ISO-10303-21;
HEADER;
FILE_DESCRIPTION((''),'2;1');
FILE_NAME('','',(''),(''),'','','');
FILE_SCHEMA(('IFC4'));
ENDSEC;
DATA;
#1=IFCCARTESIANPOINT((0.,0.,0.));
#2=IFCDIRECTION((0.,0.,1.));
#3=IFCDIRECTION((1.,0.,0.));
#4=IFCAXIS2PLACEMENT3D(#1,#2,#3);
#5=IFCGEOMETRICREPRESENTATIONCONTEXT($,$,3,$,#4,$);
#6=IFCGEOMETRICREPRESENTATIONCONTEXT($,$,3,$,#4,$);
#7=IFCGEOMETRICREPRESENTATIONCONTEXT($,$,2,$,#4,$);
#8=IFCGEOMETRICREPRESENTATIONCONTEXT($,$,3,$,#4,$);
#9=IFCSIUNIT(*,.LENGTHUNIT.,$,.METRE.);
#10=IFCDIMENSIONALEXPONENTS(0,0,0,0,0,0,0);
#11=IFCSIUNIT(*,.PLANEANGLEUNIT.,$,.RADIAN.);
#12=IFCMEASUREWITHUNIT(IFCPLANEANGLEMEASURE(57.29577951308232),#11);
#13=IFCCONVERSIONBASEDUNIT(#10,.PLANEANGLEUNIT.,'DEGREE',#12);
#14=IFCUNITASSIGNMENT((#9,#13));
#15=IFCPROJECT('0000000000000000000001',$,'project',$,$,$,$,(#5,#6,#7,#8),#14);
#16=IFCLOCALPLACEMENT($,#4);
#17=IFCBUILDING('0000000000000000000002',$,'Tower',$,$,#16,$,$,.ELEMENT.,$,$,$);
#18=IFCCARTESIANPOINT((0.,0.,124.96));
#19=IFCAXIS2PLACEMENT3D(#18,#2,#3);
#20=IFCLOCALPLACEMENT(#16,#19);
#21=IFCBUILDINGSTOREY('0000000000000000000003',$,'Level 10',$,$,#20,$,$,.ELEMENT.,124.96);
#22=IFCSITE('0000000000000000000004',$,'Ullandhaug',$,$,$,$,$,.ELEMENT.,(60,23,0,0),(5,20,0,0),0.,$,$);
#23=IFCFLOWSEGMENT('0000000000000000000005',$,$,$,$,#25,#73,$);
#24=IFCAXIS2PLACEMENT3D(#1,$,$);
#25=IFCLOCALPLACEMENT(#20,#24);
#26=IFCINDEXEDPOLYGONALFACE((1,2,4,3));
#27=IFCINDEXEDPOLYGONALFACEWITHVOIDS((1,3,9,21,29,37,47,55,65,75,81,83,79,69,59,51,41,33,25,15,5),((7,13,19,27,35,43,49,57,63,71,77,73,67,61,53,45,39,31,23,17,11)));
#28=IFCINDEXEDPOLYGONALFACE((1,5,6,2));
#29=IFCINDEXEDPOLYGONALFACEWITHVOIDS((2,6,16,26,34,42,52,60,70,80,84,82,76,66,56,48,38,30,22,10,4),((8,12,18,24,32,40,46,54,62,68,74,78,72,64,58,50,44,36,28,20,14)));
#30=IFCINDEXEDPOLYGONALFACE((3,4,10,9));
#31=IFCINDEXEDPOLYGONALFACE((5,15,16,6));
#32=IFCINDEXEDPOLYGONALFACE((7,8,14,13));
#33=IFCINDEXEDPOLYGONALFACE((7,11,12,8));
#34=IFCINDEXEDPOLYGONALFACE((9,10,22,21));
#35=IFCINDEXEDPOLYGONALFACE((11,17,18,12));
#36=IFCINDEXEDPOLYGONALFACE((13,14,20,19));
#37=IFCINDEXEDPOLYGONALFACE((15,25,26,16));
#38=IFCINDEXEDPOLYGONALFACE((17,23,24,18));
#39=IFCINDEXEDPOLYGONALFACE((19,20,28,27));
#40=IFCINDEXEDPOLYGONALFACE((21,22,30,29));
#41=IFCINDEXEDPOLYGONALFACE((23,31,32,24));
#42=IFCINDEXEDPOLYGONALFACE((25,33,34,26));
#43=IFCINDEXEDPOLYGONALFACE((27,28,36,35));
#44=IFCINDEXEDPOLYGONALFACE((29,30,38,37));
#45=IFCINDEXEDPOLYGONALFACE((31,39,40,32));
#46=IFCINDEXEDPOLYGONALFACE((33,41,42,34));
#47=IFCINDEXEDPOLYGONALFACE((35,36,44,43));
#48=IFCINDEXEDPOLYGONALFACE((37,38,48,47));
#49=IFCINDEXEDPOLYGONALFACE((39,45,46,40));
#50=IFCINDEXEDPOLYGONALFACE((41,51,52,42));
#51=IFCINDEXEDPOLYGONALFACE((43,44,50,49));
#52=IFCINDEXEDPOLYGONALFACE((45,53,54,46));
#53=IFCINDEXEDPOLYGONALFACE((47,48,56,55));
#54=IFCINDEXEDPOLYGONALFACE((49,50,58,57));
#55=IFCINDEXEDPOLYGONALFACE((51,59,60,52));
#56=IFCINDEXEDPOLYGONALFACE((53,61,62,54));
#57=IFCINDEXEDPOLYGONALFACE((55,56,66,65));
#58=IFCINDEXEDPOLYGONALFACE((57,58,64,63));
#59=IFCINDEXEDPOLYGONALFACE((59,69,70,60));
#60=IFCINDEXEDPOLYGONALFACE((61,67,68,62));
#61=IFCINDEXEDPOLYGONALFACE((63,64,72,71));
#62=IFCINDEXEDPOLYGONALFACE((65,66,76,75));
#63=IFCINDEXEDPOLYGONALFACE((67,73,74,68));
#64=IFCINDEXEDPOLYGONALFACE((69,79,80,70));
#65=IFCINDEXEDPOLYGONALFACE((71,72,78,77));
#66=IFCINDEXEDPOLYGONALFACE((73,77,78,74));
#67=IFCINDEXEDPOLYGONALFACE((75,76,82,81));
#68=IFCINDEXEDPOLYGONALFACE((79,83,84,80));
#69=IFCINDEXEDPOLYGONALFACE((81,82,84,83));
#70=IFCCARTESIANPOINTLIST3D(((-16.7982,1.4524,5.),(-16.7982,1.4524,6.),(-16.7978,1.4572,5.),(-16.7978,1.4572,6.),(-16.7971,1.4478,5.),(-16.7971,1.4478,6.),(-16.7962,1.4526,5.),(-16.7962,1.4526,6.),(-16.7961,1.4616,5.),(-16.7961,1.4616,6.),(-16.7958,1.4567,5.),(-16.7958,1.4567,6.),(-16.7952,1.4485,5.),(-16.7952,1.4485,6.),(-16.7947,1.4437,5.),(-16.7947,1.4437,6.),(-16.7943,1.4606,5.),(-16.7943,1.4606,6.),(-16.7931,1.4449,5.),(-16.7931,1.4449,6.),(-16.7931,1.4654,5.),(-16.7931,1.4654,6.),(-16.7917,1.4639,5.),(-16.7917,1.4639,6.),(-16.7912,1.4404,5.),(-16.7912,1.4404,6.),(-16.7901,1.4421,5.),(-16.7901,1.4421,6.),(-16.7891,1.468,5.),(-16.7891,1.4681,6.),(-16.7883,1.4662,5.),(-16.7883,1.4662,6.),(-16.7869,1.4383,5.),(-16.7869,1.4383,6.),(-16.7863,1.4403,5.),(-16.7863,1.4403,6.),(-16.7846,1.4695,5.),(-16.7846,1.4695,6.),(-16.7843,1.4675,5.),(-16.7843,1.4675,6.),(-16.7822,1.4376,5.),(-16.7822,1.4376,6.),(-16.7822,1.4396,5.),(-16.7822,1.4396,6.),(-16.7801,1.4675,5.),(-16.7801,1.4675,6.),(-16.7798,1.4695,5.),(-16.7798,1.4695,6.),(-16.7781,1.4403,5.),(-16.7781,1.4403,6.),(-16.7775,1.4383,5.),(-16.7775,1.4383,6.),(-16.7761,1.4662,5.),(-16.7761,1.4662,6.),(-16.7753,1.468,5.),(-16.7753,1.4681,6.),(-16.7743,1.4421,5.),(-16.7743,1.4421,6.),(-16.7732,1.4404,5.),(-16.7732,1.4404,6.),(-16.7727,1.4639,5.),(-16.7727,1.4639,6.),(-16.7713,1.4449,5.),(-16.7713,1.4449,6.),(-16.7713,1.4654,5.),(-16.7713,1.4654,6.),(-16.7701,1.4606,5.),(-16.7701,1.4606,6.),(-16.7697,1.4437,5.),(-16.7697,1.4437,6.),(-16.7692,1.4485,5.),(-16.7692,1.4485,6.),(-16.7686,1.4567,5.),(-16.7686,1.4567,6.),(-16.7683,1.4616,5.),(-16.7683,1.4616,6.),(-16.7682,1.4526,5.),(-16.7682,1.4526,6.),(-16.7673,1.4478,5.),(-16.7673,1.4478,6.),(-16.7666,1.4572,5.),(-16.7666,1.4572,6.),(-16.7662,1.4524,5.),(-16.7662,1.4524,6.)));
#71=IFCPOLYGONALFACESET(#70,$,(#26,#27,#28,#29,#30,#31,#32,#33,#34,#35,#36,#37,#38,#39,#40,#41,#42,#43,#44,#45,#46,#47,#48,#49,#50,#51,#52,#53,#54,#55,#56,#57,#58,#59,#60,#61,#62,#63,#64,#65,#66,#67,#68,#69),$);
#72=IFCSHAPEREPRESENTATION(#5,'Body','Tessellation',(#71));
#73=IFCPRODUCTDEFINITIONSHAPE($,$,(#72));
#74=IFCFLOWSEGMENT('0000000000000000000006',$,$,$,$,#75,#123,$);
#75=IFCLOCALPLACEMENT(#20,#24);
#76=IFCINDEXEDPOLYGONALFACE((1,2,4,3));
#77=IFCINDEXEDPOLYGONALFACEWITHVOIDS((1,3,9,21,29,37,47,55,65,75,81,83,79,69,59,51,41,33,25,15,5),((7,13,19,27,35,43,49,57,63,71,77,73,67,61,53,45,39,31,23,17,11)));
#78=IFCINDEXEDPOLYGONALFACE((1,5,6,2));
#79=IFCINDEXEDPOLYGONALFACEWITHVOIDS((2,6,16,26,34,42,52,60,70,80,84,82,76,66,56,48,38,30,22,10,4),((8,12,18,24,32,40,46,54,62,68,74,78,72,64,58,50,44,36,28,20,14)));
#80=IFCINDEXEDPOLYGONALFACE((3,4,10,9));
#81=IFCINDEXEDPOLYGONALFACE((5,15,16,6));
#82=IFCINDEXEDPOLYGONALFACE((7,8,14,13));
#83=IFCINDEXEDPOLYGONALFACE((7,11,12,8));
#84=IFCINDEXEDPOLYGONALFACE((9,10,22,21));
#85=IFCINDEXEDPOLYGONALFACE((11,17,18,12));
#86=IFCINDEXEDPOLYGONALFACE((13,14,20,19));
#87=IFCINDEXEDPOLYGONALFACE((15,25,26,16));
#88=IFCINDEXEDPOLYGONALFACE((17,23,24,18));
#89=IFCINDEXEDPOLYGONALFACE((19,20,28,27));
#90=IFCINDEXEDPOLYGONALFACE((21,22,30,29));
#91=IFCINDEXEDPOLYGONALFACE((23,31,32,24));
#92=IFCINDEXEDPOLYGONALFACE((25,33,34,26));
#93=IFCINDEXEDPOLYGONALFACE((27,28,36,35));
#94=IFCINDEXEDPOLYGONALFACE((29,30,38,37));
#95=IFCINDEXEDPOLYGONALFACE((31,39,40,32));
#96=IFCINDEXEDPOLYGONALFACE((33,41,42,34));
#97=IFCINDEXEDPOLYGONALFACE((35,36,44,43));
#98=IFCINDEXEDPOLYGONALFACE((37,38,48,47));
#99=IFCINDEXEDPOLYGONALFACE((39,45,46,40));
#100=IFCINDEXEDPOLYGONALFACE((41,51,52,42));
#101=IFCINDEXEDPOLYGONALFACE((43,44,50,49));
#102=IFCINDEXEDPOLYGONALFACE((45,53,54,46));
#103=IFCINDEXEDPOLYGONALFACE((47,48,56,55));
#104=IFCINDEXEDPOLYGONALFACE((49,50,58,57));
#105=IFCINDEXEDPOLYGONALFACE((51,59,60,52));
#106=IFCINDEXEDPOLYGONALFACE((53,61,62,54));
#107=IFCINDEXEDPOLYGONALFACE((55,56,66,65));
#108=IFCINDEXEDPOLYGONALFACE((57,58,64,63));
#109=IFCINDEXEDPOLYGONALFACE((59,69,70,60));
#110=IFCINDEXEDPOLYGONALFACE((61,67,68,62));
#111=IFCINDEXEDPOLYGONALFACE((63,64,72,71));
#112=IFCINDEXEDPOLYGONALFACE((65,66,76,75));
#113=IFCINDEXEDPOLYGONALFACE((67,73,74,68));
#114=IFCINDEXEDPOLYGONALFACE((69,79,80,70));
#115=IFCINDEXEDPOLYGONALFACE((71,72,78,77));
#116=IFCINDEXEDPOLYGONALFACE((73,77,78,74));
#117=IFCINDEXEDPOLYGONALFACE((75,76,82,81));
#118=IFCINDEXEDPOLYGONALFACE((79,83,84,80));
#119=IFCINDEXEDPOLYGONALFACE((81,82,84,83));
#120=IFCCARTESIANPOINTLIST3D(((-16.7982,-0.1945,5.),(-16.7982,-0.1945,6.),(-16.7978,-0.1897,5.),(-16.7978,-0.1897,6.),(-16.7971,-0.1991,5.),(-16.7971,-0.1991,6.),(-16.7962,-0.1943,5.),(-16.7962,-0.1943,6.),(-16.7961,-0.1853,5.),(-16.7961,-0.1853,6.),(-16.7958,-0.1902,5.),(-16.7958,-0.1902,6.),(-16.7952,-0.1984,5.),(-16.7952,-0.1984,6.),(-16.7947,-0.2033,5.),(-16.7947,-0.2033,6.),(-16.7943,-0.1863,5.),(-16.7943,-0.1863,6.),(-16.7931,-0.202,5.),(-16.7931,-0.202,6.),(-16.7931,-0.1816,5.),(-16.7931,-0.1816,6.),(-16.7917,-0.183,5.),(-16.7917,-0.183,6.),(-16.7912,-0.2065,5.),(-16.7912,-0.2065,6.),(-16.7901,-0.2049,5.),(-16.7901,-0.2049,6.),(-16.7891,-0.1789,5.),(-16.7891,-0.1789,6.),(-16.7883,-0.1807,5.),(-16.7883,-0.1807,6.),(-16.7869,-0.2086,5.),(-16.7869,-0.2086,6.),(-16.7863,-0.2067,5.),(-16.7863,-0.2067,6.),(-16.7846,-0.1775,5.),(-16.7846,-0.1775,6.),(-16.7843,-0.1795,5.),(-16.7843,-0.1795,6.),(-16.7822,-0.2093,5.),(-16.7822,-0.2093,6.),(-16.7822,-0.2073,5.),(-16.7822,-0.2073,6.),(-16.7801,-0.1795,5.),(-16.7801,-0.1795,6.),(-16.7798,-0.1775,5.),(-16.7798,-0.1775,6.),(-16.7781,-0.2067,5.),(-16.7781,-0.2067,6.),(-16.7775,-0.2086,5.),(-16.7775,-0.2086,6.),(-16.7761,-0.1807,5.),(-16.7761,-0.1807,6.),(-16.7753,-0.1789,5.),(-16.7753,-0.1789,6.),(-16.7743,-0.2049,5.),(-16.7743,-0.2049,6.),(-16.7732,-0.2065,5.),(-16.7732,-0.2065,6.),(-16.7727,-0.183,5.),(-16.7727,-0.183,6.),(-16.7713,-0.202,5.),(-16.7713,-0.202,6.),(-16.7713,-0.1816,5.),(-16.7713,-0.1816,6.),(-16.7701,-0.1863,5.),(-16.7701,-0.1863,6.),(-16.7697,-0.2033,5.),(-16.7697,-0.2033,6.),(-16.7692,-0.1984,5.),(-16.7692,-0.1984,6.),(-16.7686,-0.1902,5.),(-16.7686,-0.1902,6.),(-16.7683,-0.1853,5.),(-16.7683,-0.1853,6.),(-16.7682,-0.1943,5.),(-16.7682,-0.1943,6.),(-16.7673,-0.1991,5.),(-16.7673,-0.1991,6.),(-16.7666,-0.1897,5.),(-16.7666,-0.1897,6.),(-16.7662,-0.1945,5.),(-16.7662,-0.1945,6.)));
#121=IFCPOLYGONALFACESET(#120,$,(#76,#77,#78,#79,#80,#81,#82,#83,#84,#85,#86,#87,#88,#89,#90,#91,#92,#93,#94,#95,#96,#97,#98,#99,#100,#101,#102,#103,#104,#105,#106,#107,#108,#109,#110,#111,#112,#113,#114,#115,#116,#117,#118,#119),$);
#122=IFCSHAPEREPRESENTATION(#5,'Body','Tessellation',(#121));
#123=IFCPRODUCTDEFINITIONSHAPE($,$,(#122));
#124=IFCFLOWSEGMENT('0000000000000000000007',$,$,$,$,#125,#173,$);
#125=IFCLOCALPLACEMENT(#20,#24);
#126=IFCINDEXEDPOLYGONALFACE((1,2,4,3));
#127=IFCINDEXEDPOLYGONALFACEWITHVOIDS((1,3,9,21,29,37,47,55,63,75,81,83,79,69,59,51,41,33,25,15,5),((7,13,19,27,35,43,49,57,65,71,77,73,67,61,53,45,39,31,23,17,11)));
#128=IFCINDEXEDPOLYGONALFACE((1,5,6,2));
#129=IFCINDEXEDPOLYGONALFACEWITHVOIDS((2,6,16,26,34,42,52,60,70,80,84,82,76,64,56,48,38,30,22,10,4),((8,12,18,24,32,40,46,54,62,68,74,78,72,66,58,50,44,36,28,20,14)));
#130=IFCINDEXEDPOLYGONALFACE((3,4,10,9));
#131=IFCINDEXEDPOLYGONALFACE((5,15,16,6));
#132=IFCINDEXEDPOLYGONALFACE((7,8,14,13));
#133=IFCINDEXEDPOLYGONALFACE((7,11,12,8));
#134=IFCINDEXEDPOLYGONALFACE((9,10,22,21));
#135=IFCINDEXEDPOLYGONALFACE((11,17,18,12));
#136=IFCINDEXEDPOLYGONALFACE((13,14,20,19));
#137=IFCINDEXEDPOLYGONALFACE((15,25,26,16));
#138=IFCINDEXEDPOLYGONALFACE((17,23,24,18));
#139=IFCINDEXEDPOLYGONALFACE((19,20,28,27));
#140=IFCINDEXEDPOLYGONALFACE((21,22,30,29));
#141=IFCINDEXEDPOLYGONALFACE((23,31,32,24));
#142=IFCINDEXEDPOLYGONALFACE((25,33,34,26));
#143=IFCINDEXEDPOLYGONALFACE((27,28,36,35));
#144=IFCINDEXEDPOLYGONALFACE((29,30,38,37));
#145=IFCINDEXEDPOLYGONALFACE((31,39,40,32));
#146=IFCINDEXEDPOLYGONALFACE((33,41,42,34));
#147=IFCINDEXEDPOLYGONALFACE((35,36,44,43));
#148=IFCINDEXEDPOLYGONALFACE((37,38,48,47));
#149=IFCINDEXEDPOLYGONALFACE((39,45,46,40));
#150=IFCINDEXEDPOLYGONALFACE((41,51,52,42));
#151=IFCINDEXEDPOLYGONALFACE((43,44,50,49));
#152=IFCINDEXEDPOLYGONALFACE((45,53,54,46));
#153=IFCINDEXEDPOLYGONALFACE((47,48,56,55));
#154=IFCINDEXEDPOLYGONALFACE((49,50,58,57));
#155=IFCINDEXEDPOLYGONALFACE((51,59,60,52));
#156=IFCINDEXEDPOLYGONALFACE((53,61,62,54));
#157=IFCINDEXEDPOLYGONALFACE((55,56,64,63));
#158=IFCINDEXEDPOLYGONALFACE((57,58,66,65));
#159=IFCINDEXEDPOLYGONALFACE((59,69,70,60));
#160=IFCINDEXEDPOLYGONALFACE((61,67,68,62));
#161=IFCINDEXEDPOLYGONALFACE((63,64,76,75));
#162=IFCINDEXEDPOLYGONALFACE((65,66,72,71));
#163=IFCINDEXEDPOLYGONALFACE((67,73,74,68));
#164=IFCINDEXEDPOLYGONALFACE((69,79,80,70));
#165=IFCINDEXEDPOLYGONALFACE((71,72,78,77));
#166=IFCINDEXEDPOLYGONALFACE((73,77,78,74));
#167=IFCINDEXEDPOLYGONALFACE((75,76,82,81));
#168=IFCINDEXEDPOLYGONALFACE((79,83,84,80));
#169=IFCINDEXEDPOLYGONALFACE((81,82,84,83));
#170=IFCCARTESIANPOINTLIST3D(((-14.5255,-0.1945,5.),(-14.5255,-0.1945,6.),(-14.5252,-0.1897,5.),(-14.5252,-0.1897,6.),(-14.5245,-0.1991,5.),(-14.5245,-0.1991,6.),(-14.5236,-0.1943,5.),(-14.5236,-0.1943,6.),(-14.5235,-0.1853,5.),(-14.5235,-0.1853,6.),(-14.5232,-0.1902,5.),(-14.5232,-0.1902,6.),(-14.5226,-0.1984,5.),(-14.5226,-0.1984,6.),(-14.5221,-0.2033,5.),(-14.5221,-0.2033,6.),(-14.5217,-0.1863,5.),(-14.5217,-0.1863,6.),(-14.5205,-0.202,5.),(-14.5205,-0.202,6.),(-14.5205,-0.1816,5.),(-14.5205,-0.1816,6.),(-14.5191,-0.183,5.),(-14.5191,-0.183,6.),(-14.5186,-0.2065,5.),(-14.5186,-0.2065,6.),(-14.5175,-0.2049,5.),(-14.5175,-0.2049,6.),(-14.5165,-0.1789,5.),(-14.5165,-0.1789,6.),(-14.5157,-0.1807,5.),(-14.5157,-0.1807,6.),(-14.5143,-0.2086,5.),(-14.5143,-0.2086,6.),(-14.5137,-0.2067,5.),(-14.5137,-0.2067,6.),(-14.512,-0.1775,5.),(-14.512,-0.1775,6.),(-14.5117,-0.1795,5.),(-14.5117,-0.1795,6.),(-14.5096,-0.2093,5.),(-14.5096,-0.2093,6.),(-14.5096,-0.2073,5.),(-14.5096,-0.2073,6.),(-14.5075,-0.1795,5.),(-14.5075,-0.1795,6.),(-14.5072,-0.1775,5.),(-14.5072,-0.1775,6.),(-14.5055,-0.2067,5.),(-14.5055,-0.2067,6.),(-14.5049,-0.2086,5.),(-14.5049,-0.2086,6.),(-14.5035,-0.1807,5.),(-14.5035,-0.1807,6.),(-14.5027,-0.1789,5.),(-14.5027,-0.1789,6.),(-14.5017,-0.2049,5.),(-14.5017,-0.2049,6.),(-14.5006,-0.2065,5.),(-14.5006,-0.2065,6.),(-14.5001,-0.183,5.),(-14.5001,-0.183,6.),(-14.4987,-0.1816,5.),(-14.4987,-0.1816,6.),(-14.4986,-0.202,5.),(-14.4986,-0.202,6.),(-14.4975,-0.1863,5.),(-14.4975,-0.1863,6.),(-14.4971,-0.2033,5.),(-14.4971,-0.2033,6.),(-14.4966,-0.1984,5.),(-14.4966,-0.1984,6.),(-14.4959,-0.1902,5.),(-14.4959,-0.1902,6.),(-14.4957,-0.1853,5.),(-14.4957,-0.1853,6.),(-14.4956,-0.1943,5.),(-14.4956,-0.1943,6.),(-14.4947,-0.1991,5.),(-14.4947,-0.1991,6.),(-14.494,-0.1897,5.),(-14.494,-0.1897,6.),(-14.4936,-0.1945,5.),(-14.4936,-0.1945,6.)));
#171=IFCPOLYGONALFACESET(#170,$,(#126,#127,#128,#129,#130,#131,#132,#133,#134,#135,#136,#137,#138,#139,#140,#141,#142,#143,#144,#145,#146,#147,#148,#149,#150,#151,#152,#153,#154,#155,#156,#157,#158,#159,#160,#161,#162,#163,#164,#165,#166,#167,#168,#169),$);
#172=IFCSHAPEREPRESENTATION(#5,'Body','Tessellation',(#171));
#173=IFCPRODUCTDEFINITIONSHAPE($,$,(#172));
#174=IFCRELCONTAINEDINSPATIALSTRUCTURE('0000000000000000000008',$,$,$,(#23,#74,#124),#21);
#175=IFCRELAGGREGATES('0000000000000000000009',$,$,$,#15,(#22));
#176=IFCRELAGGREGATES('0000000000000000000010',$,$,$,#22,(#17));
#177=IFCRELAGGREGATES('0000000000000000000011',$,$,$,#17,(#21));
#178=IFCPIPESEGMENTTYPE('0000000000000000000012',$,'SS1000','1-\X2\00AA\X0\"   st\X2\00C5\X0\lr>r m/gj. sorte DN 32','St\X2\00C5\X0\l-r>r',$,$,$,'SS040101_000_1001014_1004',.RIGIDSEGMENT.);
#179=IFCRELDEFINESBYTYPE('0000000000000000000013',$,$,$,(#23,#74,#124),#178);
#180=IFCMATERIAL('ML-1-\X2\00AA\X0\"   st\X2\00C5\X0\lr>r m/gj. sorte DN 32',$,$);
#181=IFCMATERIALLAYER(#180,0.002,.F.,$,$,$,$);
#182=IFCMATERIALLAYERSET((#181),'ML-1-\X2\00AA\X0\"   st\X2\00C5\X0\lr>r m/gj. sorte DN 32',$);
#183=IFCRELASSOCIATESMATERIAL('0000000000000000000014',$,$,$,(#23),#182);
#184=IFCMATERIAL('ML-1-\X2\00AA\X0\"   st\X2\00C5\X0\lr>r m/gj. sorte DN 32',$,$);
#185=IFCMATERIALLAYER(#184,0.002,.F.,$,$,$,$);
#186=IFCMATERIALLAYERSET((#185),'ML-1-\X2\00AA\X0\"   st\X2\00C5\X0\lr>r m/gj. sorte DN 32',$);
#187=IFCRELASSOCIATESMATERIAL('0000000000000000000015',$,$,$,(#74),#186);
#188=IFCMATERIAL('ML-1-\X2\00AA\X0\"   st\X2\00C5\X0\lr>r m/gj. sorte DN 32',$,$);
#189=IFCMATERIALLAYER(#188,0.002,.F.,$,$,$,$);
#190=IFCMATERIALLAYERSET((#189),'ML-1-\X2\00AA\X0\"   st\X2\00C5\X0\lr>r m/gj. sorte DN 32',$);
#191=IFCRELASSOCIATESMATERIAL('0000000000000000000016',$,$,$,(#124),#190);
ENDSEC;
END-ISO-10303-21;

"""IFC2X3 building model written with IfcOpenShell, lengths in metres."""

from ifc_helpers import new_model, entity, si_unit, converted_unit, frame, origin_with_axes, origin_2d_with_axis, place, context, project, spatial, hollow_circle, extrude, material, layer, layer_set, layer_usage, type_object, element, save


model = new_model("IFC2X3")

# Units and contexts
context_of_model_1 = context(None, 3, world=origin_with_axes())
context_of_model_2 = context(None, 3, world=origin_with_axes())
context_of_model_3 = context(None, 2, world=origin_with_axes())
context_of_model_4 = context(None, 3, world=origin_with_axes())
ifc_project = project(units=[si_unit("LENGTHUNIT", "METRE"), converted_unit("PLANEANGLEUNIT", "DEGREE", entity("IfcPlaneAngleMeasure", 57.29577951308232), si_unit("PLANEANGLEUNIT", "RADIAN"), dimensions=[0, 0, 0, 0, 0, 0, 0])], contexts=[context_of_model_1, context_of_model_2, context_of_model_3, context_of_model_4])

# Site, building, storey
site = spatial("IfcSite", under=ifc_project, Name="Ullandhaug", CompositionType="ELEMENT", RefLatitude=(60, 23, 0, 0), RefLongitude=(5, 20, 0, 0), RefElevation=0.0)
building_placement = place(None, origin_with_axes())
building = spatial("IfcBuilding", under=site, at=building_placement, Name="Tower", CompositionType="ELEMENT")
storey_placement = place(building_placement, frame((0.0, 0.0, 124.96), z_axis=(0.0, 0.0, 1.0), x_axis=(1.0, 0.0, 0.0)))
storey = spatial("IfcBuildingStorey", under=building, at=storey_placement, Name="Level 10", CompositionType="ELEMENT", Elevation=124.96)

# Flow segments
pipe_segment_type_1 = type_object("IfcPipeSegmentType", Name="SS1000", Description="1-ª\"   stÅlr>r m/gj. sorte DN 32", ApplicableOccurrence="StÅl-r>r", ElementType="SS040101_000_1001014_1004", PredefinedType="RIGIDSEGMENT")
ifc_material_1 = material(Name="ML-1-ª\"   stÅlr>r m/gj. sorte DN 32")
ifc_layer_1 = layer(ifc_material_1, 0.002, ventilated=False)
ifc_layer_set_1 = layer_set([ifc_layer_1], Name="ML-1-ª\"   stÅlr>r m/gj. sorte DN 32")
ifc_layer_usage_1 = layer_usage(ifc_layer_set_1, "AXIS2", "POSITIVE", 0.0)
flow_segment_1_placement = place(storey_placement, frame((-16.7822, 1.4536, 5.0), z_axis=(0.0, 0.0, 1.0), x_axis=(0.0, -1.0, 0.0)))
element("IfcFlowSegment", 1, at=flow_segment_1_placement, inside=storey, type_object=pipe_segment_type_1, material=ifc_layer_usage_1, context=context_of_model_1, shape_type="SweptSolid", body=[
    extrude(hollow_circle(Radius=0.016, WallThickness=0.002, at=origin_2d_with_axis()), origin_with_axes(), (0.0, 0.0, 1.0), 1.0),
])
ifc_material_2 = material(Name="ML-1-ª\"   stÅlr>r m/gj. sorte DN 32")
ifc_layer_2 = layer(ifc_material_2, 0.002, ventilated=False)
ifc_layer_set_2 = layer_set([ifc_layer_2], Name="ML-1-ª\"   stÅlr>r m/gj. sorte DN 32")
ifc_layer_usage_2 = layer_usage(ifc_layer_set_2, "AXIS2", "POSITIVE", 0.0)
flow_segment_2_placement = place(storey_placement, frame((-16.7822, -0.1933, 5.0), z_axis=(0.0, 0.0, 1.0), x_axis=(0.0, -1.0, 0.0)))
element("IfcFlowSegment", 2, at=flow_segment_2_placement, inside=storey, type_object=pipe_segment_type_1, material=ifc_layer_usage_2, context=context_of_model_1, shape_type="SweptSolid", body=[
    extrude(hollow_circle(Radius=0.016, WallThickness=0.002, at=origin_2d_with_axis()), origin_with_axes(), (0.0, 0.0, 1.0), 1.0),
])
ifc_material_3 = material(Name="ML-1-ª\"   stÅlr>r m/gj. sorte DN 32")
ifc_layer_3 = layer(ifc_material_3, 0.002, ventilated=False)
ifc_layer_set_3 = layer_set([ifc_layer_3], Name="ML-1-ª\"   stÅlr>r m/gj. sorte DN 32")
ifc_layer_usage_3 = layer_usage(ifc_layer_set_3, "AXIS2", "POSITIVE", 0.0)
flow_segment_3_placement = place(storey_placement, frame((-14.5096, -0.1933, 5.0), z_axis=(0.0, 0.0, 1.0), x_axis=(0.0, -1.0, 0.0)))
element("IfcFlowSegment", 3, at=flow_segment_3_placement, inside=storey, type_object=pipe_segment_type_1, material=ifc_layer_usage_3, context=context_of_model_1, shape_type="SweptSolid", body=[
    extrude(hollow_circle(Radius=0.016, WallThickness=0.002, at=origin_2d_with_axis()), origin_with_axes(), (0.0, 0.0, 1.0), 1.0),
])

save(model, "model.ifc")
